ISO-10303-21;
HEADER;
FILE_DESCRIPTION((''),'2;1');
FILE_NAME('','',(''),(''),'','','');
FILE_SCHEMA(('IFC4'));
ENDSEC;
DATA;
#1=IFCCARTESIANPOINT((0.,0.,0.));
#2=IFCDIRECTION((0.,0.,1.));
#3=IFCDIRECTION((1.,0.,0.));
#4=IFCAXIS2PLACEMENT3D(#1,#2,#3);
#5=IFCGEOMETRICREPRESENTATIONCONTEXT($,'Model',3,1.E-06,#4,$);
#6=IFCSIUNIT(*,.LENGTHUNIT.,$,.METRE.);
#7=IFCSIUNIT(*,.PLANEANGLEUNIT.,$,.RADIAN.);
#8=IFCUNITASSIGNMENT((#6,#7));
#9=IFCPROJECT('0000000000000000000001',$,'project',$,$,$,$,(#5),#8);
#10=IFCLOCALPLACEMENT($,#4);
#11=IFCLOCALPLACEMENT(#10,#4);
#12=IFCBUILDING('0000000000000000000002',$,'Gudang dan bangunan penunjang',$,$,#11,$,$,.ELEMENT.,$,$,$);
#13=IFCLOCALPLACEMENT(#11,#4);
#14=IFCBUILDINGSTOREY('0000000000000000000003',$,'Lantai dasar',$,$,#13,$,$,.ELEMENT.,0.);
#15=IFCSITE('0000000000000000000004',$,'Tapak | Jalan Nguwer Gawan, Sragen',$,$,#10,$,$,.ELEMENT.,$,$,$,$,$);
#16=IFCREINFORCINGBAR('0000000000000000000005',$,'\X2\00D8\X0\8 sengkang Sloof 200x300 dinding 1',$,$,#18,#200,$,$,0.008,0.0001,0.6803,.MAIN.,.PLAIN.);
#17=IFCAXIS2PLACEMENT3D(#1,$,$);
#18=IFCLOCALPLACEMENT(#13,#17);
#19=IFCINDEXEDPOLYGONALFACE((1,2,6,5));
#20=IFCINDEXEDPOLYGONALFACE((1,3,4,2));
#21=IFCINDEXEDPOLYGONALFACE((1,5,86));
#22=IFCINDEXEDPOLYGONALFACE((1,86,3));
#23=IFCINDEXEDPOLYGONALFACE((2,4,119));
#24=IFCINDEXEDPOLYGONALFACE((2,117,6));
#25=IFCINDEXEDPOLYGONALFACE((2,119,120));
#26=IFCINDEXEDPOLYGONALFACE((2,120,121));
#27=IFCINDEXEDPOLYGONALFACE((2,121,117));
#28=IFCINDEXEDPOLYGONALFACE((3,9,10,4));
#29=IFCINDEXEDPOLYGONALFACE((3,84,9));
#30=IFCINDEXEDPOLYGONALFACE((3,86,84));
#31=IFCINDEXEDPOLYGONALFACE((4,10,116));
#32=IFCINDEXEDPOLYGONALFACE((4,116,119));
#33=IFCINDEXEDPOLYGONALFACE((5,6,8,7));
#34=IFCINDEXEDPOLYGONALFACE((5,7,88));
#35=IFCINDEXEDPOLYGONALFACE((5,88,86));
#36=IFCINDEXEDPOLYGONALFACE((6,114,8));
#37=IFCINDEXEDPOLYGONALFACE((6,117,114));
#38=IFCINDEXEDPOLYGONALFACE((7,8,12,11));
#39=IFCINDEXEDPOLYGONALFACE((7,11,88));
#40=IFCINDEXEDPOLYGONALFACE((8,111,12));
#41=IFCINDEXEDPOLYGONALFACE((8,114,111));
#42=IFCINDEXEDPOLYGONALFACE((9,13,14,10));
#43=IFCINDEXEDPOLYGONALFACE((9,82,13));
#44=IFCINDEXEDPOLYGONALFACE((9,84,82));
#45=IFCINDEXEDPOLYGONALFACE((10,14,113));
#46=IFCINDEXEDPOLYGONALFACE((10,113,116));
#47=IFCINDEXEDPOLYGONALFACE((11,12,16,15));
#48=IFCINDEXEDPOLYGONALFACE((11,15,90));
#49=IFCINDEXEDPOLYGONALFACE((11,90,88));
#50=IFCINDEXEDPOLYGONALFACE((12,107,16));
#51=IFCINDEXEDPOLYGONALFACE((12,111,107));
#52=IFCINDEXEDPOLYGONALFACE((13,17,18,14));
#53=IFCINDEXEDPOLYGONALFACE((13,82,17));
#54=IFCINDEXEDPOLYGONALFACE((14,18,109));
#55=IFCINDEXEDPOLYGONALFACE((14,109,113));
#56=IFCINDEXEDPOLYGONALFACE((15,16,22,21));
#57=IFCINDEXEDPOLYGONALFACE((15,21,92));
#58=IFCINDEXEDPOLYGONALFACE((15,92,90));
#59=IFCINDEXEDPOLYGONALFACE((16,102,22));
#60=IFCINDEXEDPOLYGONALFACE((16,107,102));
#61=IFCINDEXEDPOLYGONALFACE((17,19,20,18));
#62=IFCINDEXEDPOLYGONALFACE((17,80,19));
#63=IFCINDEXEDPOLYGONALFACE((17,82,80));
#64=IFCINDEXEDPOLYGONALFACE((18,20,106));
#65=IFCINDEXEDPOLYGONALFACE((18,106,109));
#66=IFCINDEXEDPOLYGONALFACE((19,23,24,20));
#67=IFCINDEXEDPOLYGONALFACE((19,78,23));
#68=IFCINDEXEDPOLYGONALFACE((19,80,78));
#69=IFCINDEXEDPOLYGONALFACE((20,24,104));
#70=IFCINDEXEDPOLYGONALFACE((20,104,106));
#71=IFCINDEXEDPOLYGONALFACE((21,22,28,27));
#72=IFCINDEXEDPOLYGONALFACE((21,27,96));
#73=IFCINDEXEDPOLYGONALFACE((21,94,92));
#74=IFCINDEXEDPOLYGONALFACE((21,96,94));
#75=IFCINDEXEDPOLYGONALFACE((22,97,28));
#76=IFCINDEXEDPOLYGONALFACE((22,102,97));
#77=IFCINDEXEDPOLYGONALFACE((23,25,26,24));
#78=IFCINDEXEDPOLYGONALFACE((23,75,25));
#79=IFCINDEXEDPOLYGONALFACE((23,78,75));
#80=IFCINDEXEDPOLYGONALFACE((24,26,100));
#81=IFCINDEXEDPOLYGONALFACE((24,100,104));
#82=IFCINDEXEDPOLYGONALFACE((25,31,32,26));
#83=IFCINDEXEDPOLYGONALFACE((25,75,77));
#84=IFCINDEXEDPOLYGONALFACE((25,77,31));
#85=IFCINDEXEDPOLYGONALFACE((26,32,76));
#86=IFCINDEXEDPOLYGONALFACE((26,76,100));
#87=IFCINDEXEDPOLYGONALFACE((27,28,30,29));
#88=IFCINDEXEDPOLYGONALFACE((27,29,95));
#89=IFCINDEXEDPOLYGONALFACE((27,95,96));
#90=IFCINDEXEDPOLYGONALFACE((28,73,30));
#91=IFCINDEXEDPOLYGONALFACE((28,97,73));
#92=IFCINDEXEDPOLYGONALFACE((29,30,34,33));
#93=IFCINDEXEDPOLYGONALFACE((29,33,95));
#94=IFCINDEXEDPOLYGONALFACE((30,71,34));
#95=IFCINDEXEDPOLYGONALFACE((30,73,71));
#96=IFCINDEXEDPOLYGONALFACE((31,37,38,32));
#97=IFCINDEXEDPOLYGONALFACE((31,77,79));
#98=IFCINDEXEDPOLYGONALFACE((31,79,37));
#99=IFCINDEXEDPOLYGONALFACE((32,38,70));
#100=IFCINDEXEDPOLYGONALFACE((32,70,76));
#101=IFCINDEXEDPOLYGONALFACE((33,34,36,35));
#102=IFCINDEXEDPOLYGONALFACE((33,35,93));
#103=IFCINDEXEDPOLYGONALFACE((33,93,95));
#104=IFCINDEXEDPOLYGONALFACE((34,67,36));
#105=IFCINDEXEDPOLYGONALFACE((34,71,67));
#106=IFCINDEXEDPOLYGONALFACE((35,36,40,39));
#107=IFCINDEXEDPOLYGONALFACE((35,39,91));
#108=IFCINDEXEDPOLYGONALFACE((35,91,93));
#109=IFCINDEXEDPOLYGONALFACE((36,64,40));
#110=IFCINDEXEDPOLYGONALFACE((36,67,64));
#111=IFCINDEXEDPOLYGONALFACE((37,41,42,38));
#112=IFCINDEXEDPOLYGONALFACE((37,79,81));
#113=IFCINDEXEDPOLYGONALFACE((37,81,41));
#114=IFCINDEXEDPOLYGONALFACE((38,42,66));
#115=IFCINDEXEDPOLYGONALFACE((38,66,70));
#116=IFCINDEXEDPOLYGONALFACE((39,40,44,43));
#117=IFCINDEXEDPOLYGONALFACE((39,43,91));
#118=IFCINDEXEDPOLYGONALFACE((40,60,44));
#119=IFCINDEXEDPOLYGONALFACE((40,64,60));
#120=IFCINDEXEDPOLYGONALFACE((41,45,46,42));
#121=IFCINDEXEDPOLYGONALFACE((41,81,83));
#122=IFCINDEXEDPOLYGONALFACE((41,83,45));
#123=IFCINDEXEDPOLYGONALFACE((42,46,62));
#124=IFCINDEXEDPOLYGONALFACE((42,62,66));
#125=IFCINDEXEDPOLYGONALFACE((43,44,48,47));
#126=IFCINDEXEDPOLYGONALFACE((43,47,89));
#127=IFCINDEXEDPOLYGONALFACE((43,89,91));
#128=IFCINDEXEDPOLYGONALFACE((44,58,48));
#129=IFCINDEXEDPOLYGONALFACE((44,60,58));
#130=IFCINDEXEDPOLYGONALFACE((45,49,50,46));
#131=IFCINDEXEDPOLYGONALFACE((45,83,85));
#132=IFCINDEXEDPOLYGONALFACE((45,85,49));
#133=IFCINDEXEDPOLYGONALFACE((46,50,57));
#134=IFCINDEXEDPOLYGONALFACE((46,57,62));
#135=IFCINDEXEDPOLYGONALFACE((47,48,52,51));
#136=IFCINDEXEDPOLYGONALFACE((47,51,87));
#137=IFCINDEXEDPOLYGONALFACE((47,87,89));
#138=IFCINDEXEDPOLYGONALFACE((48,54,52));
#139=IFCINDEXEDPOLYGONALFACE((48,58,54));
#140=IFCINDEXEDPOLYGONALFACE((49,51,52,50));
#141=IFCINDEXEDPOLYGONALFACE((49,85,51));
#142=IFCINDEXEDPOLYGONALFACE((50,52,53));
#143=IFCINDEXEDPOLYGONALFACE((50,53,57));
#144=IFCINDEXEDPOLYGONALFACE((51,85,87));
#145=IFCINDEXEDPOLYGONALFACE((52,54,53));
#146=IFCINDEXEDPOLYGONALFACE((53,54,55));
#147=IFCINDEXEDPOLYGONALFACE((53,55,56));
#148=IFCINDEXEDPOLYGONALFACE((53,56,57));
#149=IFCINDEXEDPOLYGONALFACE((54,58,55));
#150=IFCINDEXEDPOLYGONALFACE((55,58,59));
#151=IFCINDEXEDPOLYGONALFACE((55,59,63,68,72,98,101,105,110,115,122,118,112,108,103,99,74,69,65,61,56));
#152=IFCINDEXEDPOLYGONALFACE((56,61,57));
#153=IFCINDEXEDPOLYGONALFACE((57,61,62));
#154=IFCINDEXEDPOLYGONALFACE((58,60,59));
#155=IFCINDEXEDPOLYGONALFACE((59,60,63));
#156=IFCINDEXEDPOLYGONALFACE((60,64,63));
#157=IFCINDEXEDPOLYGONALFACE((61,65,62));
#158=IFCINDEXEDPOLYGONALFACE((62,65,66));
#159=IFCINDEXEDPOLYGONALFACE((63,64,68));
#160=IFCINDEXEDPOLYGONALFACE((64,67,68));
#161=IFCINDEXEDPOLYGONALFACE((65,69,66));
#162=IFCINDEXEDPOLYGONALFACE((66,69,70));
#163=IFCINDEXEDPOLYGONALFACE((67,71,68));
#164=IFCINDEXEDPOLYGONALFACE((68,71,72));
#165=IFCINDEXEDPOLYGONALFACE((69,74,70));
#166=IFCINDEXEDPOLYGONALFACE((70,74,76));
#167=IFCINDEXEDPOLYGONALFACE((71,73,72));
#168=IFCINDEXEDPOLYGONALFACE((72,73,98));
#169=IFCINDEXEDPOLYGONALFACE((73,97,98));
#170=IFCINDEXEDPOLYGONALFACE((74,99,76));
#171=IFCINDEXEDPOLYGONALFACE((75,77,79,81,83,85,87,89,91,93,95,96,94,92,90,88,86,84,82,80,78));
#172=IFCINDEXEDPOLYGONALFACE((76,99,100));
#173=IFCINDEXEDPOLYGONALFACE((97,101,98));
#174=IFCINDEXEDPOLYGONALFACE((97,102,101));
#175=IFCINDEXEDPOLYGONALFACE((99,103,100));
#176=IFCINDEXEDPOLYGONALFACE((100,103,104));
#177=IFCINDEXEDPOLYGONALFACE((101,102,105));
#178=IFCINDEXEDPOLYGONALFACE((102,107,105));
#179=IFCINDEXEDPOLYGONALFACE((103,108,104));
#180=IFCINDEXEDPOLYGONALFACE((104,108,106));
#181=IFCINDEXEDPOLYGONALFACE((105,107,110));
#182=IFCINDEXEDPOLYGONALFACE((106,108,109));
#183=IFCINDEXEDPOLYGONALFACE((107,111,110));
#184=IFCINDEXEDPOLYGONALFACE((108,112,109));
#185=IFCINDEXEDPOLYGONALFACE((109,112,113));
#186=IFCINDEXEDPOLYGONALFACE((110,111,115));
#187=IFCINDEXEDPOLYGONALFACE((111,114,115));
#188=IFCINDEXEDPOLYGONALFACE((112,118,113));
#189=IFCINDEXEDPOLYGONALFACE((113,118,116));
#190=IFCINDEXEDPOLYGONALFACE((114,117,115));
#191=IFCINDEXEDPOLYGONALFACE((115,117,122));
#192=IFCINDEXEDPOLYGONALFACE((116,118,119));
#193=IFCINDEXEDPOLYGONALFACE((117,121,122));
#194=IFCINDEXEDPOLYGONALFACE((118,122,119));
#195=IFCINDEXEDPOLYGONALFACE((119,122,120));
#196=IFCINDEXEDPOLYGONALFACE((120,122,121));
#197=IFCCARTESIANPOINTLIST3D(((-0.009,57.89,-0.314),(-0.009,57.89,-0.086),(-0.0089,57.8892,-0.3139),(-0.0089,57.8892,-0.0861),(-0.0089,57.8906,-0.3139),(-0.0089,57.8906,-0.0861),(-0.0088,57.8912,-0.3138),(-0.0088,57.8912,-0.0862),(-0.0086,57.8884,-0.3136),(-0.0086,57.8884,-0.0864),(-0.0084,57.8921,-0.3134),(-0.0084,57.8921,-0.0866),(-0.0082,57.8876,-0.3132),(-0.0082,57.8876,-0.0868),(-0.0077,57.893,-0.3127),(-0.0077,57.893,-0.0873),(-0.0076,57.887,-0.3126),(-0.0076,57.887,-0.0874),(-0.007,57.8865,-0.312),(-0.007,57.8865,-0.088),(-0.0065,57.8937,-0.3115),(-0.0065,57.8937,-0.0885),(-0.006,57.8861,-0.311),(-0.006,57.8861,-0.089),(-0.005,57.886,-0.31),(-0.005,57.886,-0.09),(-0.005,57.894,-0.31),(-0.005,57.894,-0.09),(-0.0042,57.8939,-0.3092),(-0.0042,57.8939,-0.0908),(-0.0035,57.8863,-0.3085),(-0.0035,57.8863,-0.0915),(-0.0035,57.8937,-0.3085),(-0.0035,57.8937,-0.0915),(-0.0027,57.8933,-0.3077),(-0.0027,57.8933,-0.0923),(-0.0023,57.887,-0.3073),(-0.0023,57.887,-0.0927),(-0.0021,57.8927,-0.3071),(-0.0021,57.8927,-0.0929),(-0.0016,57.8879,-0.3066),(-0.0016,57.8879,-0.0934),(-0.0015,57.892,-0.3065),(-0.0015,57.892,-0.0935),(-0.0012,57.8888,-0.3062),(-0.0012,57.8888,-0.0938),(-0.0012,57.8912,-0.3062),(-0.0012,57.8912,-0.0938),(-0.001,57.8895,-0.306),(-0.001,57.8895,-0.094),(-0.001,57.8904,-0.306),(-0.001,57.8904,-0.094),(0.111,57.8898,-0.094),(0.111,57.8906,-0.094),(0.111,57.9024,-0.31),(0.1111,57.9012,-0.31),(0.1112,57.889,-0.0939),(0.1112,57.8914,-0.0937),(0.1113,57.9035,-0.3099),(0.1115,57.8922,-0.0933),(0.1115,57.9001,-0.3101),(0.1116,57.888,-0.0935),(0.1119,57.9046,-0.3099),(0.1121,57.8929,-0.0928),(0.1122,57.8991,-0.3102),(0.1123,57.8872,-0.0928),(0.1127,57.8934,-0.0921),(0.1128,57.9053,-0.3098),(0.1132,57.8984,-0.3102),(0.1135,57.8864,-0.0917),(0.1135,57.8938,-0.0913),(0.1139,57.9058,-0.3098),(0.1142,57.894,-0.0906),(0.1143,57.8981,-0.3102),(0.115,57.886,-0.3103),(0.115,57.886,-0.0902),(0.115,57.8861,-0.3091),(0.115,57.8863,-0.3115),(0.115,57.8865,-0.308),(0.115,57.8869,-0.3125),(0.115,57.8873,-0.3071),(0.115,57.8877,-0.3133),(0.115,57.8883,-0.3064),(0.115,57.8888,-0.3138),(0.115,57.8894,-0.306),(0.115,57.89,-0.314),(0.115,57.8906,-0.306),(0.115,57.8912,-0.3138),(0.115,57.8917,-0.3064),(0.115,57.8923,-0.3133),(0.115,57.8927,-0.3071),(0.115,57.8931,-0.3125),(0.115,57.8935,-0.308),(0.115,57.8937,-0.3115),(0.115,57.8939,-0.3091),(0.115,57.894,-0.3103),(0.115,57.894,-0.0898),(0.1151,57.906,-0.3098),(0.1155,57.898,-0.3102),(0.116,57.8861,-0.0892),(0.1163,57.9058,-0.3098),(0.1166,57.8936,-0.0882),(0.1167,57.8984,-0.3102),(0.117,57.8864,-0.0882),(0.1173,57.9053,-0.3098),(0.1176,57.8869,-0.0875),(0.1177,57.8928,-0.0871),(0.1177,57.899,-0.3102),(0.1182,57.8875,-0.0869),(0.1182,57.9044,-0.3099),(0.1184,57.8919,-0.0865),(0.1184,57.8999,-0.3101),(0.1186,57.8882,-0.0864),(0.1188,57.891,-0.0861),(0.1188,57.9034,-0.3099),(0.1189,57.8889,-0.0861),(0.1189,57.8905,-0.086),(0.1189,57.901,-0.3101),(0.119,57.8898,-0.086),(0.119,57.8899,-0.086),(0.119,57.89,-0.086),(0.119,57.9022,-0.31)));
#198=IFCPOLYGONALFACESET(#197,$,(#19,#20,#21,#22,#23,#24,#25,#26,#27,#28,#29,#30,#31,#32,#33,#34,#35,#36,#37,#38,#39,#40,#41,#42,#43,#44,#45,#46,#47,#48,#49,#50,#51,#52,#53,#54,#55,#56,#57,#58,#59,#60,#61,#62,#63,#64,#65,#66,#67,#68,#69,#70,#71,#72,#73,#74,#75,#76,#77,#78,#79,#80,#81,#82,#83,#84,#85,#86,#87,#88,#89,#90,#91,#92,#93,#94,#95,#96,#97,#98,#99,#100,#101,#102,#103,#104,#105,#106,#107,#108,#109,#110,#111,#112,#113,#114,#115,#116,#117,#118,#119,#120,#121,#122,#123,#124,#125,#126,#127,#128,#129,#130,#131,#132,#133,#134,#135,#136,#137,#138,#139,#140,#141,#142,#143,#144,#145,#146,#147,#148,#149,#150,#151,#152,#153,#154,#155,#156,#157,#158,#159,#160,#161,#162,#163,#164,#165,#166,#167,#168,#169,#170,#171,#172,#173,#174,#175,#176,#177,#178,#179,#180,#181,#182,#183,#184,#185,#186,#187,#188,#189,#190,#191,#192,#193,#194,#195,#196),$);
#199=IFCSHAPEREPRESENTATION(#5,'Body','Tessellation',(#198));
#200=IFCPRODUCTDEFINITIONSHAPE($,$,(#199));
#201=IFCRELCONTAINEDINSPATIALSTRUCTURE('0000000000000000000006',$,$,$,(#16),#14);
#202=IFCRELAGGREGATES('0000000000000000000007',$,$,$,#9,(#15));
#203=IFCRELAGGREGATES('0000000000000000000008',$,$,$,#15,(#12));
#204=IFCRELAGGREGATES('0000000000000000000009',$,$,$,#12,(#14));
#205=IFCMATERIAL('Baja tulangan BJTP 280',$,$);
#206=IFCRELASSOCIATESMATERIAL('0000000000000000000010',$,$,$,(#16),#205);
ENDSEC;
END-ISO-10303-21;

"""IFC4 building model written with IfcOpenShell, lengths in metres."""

from ifc_helpers import new_model, entity, si_unit, origin_with_axes, place, context, project, spatial, material, element, save


model = new_model("IFC4")

# Units and contexts
model_context = context("Model", 3, precision=1e-06, world=origin_with_axes())
ifc_project = project(units=[si_unit("LENGTHUNIT", "METRE"), si_unit("PLANEANGLEUNIT", "RADIAN")], contexts=[model_context])

# Site, building, storey
site_placement = place(None, origin_with_axes())
site = spatial("IfcSite", under=ifc_project, at=site_placement, Name="Tapak | Jalan Nguwer Gawan, Sragen", CompositionType="ELEMENT")
building_placement = place(site_placement, origin_with_axes())
building = spatial("IfcBuilding", under=site, at=building_placement, Name="Gudang dan bangunan penunjang", CompositionType="ELEMENT")
storey_placement = place(building_placement, origin_with_axes())
storey = spatial("IfcBuildingStorey", under=building, at=storey_placement, Name="Lantai dasar", CompositionType="ELEMENT", Elevation=0.0)

# Shared definitions
placement = place(None, origin_with_axes())

# Reinforcing bar
ifc_material_1 = material(Name="Baja tulangan BJTP 280")
element("IfcReinforcingBar", 1, at=placement, inside=storey, material=ifc_material_1, Name="Ø8 sengkang Sloof 200x300 dinding 1", BarLength=0.6803, BarSurface="PLAIN", CrossSectionArea=0.0001, NominalDiameter=0.008, PredefinedType="MAIN", context=model_context, shape_type="AdvancedSweptSolid", body=[
    entity("IfcSweptDiskSolid", entity("IfcPolyline", [entity("IfcCartesianPoint", [0.115, 57.89, -0.31]), entity("IfcCartesianPoint", [-0.005, 57.89, -0.31]), entity("IfcCartesianPoint", [-0.005, 57.89, -0.09]), entity("IfcCartesianPoint", [0.115, 57.89, -0.09]), entity("IfcCartesianPoint", [0.115, 57.902, -0.31])]), 0.004),
])

save(model, "model.ifc")
